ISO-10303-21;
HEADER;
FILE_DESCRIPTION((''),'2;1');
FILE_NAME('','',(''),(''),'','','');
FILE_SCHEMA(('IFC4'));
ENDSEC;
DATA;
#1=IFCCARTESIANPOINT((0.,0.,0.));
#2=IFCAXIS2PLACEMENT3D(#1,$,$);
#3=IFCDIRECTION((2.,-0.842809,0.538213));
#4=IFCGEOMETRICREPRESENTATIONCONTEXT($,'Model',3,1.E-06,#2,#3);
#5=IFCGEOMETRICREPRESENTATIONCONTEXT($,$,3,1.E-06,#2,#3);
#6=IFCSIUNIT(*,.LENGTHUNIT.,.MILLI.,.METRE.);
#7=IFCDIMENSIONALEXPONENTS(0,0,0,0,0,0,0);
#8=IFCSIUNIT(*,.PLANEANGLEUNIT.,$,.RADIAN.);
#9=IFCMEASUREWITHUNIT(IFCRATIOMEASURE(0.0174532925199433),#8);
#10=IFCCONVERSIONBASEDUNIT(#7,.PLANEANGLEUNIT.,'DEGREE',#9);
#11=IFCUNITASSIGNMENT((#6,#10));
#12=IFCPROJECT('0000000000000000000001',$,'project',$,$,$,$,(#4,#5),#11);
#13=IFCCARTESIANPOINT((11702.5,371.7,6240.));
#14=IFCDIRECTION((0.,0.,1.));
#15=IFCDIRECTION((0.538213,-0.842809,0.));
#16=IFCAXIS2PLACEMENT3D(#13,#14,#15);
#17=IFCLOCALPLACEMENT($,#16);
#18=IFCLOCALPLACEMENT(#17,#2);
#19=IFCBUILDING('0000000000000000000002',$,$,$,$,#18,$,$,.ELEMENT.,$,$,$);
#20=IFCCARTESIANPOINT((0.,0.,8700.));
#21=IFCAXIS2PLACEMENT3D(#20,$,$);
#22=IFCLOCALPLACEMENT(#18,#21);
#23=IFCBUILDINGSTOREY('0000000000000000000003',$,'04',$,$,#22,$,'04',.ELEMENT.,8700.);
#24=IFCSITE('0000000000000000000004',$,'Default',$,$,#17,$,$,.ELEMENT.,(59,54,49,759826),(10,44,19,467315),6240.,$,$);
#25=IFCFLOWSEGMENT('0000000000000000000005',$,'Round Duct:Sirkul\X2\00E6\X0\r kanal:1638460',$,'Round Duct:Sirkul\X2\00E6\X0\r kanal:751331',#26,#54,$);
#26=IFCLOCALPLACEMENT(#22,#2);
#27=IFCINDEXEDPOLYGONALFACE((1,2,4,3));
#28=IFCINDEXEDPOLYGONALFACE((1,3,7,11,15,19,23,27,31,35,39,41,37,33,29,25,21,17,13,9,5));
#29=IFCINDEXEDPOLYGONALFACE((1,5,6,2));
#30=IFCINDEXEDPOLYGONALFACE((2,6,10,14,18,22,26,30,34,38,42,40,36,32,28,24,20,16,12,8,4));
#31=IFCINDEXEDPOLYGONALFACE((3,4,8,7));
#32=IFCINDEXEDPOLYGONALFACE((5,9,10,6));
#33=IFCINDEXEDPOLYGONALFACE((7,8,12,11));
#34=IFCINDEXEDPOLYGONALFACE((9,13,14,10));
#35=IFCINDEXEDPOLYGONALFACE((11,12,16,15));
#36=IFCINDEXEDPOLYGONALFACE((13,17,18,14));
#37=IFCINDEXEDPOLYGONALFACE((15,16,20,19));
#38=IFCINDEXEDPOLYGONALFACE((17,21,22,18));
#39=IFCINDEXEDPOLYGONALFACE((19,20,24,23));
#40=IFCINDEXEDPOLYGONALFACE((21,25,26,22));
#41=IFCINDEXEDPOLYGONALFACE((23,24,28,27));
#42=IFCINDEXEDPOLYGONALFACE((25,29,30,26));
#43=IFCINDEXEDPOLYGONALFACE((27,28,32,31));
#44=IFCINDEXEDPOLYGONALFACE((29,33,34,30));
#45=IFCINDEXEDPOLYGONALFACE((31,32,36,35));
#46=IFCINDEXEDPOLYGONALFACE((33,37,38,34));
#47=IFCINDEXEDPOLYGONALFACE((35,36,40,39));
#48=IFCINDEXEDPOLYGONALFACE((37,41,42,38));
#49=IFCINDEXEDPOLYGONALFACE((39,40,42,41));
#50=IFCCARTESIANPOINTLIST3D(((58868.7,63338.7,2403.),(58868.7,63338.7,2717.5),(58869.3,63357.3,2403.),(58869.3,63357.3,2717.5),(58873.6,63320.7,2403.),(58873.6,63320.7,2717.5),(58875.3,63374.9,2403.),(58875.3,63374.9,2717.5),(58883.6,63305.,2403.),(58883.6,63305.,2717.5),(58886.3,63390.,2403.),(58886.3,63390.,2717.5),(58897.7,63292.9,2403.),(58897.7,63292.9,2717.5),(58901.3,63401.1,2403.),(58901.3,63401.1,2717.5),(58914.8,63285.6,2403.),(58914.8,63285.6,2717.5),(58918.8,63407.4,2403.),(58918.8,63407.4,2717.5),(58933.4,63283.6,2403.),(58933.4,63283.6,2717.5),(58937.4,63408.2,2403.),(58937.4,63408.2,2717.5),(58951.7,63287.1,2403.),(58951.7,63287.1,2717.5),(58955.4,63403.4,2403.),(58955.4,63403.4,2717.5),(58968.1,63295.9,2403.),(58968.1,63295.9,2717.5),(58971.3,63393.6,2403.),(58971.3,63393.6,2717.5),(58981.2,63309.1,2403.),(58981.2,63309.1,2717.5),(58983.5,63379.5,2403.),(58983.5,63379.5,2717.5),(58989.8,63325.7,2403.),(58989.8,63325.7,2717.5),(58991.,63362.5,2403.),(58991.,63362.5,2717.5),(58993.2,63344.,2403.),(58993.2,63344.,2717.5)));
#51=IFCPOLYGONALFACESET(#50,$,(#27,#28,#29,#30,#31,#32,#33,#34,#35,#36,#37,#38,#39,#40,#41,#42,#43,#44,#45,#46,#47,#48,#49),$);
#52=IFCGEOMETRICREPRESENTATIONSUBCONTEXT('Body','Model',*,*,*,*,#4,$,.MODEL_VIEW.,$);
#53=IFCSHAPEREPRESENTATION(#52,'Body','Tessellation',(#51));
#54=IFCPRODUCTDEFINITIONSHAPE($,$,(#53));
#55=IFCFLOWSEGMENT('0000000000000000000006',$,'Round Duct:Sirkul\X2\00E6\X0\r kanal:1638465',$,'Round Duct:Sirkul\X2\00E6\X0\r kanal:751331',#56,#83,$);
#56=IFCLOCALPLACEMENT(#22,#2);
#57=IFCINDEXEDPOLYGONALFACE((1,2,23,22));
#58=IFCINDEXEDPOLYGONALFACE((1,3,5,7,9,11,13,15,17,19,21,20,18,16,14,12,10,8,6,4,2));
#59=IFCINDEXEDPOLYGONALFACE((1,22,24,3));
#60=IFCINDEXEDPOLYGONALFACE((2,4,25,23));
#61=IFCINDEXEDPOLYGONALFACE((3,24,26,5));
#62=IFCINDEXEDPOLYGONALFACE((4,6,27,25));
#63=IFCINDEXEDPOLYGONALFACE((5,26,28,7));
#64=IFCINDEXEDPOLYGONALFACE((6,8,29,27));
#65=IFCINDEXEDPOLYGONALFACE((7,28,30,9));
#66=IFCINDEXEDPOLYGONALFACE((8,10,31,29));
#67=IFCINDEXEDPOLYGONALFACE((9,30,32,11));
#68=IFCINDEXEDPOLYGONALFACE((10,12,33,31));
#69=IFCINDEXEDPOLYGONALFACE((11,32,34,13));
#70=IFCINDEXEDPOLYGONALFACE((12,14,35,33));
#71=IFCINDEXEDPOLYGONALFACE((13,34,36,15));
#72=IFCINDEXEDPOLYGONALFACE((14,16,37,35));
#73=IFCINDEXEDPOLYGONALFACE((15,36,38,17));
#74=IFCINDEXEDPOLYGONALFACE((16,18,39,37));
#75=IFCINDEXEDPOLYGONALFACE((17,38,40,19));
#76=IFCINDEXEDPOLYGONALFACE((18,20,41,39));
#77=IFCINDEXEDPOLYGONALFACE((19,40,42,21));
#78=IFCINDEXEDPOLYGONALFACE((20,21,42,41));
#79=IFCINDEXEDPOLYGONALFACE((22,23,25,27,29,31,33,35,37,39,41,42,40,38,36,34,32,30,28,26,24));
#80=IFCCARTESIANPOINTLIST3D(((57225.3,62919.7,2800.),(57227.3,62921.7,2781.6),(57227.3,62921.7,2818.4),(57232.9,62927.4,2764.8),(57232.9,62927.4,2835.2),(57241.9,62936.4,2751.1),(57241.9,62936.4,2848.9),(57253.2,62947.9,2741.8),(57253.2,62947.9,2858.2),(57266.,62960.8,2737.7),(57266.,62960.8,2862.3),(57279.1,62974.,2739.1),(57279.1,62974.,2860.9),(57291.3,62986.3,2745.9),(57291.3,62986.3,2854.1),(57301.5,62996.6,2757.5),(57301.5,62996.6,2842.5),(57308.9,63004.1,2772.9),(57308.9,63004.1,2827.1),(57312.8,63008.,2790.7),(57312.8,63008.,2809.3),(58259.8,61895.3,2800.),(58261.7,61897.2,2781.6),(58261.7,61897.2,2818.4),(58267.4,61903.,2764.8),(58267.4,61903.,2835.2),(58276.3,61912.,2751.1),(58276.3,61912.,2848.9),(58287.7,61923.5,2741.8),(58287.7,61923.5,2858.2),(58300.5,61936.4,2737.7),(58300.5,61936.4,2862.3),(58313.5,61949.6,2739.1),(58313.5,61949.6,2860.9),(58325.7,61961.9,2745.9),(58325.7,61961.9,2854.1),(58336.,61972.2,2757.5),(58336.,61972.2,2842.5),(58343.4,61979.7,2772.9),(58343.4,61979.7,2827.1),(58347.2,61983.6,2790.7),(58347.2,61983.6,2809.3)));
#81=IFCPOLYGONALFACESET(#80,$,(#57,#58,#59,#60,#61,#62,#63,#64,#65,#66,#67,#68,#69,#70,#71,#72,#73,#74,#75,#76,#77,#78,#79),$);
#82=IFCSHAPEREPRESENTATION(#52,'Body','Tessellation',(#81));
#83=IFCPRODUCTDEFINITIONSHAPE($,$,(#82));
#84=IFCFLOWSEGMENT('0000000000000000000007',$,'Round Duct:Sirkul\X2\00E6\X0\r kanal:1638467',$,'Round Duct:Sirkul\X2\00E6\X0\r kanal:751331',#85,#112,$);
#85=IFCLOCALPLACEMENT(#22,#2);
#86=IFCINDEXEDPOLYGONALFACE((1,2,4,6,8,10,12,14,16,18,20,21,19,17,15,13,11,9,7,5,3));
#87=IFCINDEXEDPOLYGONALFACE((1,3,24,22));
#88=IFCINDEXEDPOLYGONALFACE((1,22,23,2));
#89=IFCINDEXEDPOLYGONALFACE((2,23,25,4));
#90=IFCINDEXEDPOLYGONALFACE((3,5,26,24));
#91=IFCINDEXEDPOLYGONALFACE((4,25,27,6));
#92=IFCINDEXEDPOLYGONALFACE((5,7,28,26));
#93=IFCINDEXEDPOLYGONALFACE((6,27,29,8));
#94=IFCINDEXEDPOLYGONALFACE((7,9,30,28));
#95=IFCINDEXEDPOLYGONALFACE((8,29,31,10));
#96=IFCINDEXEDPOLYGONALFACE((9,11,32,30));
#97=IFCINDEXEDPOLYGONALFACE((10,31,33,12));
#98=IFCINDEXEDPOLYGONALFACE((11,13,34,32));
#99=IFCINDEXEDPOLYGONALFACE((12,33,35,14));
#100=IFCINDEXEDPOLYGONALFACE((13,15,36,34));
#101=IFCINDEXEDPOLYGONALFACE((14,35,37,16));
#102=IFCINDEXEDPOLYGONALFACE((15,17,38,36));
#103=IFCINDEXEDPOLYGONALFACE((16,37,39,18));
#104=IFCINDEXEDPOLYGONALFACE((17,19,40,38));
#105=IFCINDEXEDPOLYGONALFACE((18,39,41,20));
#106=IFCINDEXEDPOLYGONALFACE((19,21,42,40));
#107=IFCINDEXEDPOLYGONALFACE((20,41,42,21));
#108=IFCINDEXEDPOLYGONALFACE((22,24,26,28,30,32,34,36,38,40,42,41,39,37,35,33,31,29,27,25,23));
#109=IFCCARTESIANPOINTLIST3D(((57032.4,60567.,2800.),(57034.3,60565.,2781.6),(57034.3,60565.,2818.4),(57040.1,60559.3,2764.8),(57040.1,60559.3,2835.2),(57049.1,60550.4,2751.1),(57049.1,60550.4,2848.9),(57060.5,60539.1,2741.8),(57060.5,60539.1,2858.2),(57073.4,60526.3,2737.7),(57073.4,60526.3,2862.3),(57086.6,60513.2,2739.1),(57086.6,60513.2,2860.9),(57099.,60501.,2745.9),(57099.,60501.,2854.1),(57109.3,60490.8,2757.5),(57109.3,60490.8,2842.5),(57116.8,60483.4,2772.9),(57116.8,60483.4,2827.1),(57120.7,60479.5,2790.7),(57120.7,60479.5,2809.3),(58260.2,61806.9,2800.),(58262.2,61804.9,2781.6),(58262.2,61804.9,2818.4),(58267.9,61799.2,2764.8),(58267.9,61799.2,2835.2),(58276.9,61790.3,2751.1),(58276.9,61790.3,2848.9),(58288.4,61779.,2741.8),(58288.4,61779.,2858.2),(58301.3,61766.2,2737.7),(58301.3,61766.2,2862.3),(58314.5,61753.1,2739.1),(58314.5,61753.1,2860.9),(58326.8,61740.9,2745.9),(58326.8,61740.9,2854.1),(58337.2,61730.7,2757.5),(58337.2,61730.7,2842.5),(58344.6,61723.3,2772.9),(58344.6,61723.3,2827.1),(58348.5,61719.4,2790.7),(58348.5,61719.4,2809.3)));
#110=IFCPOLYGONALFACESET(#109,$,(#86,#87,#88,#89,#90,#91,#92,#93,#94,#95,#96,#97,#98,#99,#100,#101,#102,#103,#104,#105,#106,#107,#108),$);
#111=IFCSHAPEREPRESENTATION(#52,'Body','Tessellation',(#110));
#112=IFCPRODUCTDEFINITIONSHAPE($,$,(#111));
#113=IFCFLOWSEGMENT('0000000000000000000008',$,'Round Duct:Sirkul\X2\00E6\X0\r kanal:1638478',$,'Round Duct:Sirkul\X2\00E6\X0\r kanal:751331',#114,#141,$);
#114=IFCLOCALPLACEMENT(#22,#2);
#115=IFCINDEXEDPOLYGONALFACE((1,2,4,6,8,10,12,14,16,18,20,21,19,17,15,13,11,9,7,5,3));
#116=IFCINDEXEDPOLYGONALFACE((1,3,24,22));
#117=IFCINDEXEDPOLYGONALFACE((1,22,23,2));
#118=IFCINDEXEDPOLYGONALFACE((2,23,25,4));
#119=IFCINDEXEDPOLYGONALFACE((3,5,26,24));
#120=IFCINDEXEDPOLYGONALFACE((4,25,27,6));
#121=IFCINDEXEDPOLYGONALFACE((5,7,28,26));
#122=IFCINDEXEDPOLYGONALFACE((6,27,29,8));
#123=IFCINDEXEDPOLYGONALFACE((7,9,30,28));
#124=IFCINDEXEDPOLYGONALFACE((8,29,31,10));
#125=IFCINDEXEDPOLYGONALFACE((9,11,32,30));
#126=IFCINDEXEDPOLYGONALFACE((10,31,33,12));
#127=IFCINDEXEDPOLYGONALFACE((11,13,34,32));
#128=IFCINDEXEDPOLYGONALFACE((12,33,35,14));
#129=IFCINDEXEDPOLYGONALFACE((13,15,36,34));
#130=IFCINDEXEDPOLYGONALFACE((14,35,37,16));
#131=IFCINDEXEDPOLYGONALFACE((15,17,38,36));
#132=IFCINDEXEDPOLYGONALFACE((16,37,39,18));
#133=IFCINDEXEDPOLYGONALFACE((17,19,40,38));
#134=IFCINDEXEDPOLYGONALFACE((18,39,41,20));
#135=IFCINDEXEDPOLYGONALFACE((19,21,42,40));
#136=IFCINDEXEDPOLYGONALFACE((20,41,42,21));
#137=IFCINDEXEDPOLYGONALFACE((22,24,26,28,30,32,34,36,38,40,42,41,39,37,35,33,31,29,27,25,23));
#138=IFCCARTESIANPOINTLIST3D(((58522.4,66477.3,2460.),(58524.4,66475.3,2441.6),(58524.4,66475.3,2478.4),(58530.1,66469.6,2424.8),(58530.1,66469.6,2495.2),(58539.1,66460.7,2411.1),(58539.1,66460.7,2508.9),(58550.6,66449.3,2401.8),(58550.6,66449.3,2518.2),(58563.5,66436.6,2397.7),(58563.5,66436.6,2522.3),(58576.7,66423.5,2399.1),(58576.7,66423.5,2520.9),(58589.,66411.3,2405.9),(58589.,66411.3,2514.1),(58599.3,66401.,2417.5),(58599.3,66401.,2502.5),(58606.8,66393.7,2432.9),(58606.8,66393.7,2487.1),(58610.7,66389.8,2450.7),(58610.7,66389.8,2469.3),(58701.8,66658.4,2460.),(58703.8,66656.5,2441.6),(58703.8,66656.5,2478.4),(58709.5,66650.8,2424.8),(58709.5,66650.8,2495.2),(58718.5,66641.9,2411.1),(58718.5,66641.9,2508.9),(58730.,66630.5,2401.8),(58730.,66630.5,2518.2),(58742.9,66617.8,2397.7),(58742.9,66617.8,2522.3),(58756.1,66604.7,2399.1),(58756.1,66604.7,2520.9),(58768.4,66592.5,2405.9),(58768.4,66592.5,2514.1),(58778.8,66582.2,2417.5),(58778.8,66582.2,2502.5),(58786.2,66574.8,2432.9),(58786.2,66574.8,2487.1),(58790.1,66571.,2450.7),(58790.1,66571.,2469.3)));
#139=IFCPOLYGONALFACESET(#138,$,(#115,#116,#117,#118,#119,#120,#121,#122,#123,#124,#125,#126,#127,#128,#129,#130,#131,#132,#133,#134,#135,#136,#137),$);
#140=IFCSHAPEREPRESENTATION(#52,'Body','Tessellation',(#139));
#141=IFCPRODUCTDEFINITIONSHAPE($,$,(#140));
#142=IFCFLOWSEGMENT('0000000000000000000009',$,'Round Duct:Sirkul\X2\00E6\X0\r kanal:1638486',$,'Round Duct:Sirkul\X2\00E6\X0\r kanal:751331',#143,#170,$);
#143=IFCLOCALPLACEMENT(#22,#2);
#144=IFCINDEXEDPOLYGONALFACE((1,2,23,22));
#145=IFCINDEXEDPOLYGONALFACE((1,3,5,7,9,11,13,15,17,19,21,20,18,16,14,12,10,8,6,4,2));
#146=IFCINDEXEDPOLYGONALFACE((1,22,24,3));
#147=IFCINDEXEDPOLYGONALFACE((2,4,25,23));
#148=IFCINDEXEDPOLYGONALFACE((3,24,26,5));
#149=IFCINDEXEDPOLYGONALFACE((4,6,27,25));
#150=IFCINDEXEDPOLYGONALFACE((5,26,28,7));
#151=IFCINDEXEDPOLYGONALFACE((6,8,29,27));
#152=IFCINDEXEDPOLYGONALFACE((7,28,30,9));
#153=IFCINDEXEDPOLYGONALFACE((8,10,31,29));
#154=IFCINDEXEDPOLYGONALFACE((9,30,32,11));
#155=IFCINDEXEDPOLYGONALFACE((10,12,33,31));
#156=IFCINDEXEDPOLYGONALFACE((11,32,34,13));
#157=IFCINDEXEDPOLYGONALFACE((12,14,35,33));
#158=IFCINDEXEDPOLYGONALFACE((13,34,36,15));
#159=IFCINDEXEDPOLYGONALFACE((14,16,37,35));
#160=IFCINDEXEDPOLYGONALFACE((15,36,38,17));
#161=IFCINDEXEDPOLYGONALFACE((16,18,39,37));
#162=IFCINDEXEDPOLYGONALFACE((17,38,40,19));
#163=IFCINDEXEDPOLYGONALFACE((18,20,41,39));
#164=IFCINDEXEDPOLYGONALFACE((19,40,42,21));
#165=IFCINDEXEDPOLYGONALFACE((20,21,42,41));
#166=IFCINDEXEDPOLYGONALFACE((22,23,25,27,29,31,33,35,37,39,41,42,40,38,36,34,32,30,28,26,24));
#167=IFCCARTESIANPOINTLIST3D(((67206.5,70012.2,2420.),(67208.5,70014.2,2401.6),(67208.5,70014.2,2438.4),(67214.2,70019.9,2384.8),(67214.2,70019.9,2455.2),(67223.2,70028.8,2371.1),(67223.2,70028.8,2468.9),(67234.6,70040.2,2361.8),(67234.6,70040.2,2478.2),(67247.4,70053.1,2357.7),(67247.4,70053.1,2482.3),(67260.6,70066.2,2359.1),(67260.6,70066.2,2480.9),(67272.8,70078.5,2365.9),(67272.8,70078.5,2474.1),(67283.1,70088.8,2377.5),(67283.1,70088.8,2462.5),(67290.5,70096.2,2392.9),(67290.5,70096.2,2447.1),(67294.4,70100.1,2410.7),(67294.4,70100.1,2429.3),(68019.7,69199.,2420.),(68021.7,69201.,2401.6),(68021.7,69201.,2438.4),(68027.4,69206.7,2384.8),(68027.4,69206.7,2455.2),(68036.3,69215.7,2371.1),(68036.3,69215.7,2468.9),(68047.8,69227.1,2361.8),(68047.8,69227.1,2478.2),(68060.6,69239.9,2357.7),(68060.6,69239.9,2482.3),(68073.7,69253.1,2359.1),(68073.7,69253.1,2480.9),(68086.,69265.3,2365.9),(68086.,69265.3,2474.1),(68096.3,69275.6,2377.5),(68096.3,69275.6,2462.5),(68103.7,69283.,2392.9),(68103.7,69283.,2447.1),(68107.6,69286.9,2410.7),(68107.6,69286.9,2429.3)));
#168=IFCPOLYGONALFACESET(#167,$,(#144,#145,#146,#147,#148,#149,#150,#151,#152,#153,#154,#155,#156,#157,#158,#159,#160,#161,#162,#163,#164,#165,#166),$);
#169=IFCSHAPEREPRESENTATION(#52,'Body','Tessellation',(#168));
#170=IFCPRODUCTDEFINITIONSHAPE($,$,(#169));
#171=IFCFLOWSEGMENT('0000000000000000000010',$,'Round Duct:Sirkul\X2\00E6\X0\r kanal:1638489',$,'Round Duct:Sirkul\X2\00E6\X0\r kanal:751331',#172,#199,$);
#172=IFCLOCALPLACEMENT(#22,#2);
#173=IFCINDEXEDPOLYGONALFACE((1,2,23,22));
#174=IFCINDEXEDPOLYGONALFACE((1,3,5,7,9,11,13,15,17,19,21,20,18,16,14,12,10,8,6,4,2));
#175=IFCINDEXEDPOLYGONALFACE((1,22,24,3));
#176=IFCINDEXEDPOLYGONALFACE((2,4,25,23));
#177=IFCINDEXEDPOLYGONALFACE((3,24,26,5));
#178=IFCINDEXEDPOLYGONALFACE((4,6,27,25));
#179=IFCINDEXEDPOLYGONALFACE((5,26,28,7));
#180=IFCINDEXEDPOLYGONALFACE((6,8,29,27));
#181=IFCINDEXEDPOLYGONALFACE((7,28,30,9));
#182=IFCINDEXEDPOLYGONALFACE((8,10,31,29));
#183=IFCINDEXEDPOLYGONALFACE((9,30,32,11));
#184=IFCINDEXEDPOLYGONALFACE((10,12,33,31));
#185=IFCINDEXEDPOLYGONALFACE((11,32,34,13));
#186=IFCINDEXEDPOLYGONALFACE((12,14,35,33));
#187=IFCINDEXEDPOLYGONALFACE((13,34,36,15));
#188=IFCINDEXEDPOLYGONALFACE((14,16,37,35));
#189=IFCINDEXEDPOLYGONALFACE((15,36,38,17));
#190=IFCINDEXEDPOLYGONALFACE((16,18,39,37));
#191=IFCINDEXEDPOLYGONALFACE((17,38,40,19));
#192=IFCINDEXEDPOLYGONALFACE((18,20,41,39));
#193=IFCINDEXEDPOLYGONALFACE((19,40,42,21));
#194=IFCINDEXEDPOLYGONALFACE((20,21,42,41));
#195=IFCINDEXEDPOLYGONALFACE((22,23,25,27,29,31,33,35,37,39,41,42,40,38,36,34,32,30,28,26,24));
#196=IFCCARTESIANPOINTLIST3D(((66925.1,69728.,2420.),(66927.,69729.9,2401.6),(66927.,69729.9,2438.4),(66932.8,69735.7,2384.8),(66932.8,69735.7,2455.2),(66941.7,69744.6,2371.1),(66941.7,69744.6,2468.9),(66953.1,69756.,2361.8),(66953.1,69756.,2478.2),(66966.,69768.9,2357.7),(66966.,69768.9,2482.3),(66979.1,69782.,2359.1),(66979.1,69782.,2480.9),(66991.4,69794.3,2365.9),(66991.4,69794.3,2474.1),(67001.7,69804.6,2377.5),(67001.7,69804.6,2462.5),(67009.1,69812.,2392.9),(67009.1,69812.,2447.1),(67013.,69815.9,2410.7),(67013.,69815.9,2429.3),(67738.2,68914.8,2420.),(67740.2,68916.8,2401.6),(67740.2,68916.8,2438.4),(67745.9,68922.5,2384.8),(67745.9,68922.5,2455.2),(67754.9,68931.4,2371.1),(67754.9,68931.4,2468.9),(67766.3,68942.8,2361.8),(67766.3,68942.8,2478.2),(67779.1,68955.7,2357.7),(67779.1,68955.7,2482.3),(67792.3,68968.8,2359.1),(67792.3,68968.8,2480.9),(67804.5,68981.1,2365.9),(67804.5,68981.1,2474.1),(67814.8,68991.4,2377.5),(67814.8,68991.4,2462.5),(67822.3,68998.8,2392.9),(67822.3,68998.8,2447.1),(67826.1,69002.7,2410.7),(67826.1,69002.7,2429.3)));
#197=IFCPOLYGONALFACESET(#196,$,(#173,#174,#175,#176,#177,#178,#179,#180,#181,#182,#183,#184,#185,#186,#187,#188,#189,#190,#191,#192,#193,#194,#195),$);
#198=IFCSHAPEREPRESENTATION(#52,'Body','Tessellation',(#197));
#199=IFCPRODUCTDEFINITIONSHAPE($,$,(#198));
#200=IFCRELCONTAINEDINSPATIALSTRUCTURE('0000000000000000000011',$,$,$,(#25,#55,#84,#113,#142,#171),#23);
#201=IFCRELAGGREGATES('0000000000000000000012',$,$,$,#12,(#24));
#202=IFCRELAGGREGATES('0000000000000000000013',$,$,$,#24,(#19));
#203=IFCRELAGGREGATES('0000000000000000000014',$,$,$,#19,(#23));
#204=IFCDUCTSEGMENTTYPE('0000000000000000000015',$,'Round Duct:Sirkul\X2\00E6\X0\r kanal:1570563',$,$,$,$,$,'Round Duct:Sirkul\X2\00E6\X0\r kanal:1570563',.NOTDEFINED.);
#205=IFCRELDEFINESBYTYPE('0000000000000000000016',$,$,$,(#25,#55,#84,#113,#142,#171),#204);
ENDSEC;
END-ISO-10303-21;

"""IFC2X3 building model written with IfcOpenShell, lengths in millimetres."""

from ifc_helpers import new_model, entity, si_unit, converted_unit, direction, frame, frame_2d, origin, origin_2d_with_axis, place, context, subcontext, project, spatial, circle, extrude, type_object, element, save


model = new_model("IFC2X3")

# Units and contexts
model_context = context("Model", 3, precision=1e-06, world=origin(), true_north=direction((2.0, -0.842809, 0.538213)))
context_of_model = context(None, 3, precision=1e-06, world=origin(), true_north=direction((2.0, -0.842809, 0.538213)))
body_context = subcontext(model_context, "Body", "Model", "MODEL_VIEW")
ifc_project = project(units=[si_unit("LENGTHUNIT", "METRE", prefix="MILLI"), converted_unit("PLANEANGLEUNIT", "DEGREE", entity("IfcRatioMeasure", 0.0174532925199433), si_unit("PLANEANGLEUNIT", "RADIAN"), dimensions=[0, 0, 0, 0, 0, 0, 0])], contexts=[model_context, context_of_model])

# Site, building, storey
site_placement = place(None, frame((11702.5, 371.7, 6240.0), z_axis=(0.0, 0.0, 1.0), x_axis=(0.538213, -0.842809, 0.0)))
site = spatial("IfcSite", under=ifc_project, at=site_placement, Name="Default", CompositionType="ELEMENT", RefLatitude=(59, 54, 49, 759826), RefLongitude=(10, 44, 19, 467315), RefElevation=6240.0)
building_placement = place(site_placement, origin())
building = spatial("IfcBuilding", under=site, at=building_placement, CompositionType="ELEMENT")
storey_placement = place(building_placement, frame((0.0, 0.0, 8700.0)))
storey = spatial("IfcBuildingStorey", under=building, at=storey_placement, Name="04", LongName="04", CompositionType="ELEMENT", Elevation=8700.0)

# Flow segments
duct_segment_type = type_object("IfcDuctSegmentType", Name="Round Duct:Sirkulær kanal:1570563", ElementType="Round Duct:Sirkulær kanal:1570563", PredefinedType="NOTDEFINED")
flow_segment_1_placement = place(storey_placement, origin())
element("IfcFlowSegment", 1, at=flow_segment_1_placement, inside=storey, type_object=duct_segment_type, Name="Round Duct:Sirkulær kanal:1638460", ObjectType="Round Duct:Sirkulær kanal:751331", context=body_context, shape_type="SweptSolid", body=[
    extrude(circle(Radius=62.5, at=frame_2d((0.0, 0.0), x_axis=(1.0, 0.0))), frame((58930.7, 63346.0, 2403.0), z_axis=(0.0, 0.0, 1.0), x_axis=(-0.710554, 0.703643, 0.0)), (0.0, 0.0, 1.0), 314.5),
])
flow_segment_2_placement = place(storey_placement, origin())
element("IfcFlowSegment", 2, at=flow_segment_2_placement, inside=storey, type_object=duct_segment_type, Name="Round Duct:Sirkulær kanal:1638465", ObjectType="Round Duct:Sirkulær kanal:751331", context=body_context, shape_type="SweptSolid", body=[
    extrude(circle(Radius=62.5, at=origin_2d_with_axis()), frame((57269.3, 62964.1, 2800.0), z_axis=(0.710552, -0.703645, 0.0), x_axis=(-0.703645, -0.710552, 0.0)), (0.0, 0.0, 1.0), 1455.9),
])
flow_segment_3_placement = place(storey_placement, origin())
element("IfcFlowSegment", 3, at=flow_segment_3_placement, inside=storey, type_object=duct_segment_type, Name="Round Duct:Sirkulær kanal:1638467", ObjectType="Round Duct:Sirkulær kanal:751331", context=body_context, shape_type="SweptSolid", body=[
    extrude(circle(Radius=62.5, at=origin_2d_with_axis()), frame((57076.8, 60523.0, 2800.0), z_axis=(0.703643, 0.710554, 0.0), x_axis=(-0.710554, 0.703643, 0.0)), (0.0, 0.0, 1.0), 1745.0),
])
flow_segment_4_placement = place(storey_placement, origin())
element("IfcFlowSegment", 4, at=flow_segment_4_placement, inside=storey, type_object=duct_segment_type, Name="Round Duct:Sirkulær kanal:1638478", ObjectType="Round Duct:Sirkulær kanal:751331", context=body_context, shape_type="SweptSolid", body=[
    extrude(circle(Radius=62.5, at=origin_2d_with_axis()), frame((58566.8, 66433.3, 2460.0), z_axis=(0.703661, 0.710536, 0.0), x_axis=(-0.710536, 0.703661, 0.0)), (0.0, 0.0, 1.0), 255.0),
])
flow_segment_5_placement = place(storey_placement, origin())
element("IfcFlowSegment", 5, at=flow_segment_5_placement, inside=storey, type_object=duct_segment_type, Name="Round Duct:Sirkulær kanal:1638486", ObjectType="Round Duct:Sirkulær kanal:751331", context=body_context, shape_type="SweptSolid", body=[
    extrude(circle(Radius=62.5, at=origin_2d_with_axis()), frame((67250.7, 70056.4, 2420.0), z_axis=(0.707107, -0.707107, 0.0), x_axis=(-0.707107, -0.707107, 0.0)), (0.0, 0.0, 1.0), 1150.0),
])
flow_segment_6_placement = place(storey_placement, origin())
element("IfcFlowSegment", 6, at=flow_segment_6_placement, inside=storey, type_object=duct_segment_type, Name="Round Duct:Sirkulær kanal:1638489", ObjectType="Round Duct:Sirkulær kanal:751331", context=body_context, shape_type="SweptSolid", body=[
    extrude(circle(Radius=62.5, at=origin_2d_with_axis()), frame((66969.3, 69772.2, 2420.0), z_axis=(0.707107, -0.707107, 0.0), x_axis=(-0.707107, -0.707107, 0.0)), (0.0, 0.0, 1.0), 1150.0),
])

save(model, "model.ifc")
